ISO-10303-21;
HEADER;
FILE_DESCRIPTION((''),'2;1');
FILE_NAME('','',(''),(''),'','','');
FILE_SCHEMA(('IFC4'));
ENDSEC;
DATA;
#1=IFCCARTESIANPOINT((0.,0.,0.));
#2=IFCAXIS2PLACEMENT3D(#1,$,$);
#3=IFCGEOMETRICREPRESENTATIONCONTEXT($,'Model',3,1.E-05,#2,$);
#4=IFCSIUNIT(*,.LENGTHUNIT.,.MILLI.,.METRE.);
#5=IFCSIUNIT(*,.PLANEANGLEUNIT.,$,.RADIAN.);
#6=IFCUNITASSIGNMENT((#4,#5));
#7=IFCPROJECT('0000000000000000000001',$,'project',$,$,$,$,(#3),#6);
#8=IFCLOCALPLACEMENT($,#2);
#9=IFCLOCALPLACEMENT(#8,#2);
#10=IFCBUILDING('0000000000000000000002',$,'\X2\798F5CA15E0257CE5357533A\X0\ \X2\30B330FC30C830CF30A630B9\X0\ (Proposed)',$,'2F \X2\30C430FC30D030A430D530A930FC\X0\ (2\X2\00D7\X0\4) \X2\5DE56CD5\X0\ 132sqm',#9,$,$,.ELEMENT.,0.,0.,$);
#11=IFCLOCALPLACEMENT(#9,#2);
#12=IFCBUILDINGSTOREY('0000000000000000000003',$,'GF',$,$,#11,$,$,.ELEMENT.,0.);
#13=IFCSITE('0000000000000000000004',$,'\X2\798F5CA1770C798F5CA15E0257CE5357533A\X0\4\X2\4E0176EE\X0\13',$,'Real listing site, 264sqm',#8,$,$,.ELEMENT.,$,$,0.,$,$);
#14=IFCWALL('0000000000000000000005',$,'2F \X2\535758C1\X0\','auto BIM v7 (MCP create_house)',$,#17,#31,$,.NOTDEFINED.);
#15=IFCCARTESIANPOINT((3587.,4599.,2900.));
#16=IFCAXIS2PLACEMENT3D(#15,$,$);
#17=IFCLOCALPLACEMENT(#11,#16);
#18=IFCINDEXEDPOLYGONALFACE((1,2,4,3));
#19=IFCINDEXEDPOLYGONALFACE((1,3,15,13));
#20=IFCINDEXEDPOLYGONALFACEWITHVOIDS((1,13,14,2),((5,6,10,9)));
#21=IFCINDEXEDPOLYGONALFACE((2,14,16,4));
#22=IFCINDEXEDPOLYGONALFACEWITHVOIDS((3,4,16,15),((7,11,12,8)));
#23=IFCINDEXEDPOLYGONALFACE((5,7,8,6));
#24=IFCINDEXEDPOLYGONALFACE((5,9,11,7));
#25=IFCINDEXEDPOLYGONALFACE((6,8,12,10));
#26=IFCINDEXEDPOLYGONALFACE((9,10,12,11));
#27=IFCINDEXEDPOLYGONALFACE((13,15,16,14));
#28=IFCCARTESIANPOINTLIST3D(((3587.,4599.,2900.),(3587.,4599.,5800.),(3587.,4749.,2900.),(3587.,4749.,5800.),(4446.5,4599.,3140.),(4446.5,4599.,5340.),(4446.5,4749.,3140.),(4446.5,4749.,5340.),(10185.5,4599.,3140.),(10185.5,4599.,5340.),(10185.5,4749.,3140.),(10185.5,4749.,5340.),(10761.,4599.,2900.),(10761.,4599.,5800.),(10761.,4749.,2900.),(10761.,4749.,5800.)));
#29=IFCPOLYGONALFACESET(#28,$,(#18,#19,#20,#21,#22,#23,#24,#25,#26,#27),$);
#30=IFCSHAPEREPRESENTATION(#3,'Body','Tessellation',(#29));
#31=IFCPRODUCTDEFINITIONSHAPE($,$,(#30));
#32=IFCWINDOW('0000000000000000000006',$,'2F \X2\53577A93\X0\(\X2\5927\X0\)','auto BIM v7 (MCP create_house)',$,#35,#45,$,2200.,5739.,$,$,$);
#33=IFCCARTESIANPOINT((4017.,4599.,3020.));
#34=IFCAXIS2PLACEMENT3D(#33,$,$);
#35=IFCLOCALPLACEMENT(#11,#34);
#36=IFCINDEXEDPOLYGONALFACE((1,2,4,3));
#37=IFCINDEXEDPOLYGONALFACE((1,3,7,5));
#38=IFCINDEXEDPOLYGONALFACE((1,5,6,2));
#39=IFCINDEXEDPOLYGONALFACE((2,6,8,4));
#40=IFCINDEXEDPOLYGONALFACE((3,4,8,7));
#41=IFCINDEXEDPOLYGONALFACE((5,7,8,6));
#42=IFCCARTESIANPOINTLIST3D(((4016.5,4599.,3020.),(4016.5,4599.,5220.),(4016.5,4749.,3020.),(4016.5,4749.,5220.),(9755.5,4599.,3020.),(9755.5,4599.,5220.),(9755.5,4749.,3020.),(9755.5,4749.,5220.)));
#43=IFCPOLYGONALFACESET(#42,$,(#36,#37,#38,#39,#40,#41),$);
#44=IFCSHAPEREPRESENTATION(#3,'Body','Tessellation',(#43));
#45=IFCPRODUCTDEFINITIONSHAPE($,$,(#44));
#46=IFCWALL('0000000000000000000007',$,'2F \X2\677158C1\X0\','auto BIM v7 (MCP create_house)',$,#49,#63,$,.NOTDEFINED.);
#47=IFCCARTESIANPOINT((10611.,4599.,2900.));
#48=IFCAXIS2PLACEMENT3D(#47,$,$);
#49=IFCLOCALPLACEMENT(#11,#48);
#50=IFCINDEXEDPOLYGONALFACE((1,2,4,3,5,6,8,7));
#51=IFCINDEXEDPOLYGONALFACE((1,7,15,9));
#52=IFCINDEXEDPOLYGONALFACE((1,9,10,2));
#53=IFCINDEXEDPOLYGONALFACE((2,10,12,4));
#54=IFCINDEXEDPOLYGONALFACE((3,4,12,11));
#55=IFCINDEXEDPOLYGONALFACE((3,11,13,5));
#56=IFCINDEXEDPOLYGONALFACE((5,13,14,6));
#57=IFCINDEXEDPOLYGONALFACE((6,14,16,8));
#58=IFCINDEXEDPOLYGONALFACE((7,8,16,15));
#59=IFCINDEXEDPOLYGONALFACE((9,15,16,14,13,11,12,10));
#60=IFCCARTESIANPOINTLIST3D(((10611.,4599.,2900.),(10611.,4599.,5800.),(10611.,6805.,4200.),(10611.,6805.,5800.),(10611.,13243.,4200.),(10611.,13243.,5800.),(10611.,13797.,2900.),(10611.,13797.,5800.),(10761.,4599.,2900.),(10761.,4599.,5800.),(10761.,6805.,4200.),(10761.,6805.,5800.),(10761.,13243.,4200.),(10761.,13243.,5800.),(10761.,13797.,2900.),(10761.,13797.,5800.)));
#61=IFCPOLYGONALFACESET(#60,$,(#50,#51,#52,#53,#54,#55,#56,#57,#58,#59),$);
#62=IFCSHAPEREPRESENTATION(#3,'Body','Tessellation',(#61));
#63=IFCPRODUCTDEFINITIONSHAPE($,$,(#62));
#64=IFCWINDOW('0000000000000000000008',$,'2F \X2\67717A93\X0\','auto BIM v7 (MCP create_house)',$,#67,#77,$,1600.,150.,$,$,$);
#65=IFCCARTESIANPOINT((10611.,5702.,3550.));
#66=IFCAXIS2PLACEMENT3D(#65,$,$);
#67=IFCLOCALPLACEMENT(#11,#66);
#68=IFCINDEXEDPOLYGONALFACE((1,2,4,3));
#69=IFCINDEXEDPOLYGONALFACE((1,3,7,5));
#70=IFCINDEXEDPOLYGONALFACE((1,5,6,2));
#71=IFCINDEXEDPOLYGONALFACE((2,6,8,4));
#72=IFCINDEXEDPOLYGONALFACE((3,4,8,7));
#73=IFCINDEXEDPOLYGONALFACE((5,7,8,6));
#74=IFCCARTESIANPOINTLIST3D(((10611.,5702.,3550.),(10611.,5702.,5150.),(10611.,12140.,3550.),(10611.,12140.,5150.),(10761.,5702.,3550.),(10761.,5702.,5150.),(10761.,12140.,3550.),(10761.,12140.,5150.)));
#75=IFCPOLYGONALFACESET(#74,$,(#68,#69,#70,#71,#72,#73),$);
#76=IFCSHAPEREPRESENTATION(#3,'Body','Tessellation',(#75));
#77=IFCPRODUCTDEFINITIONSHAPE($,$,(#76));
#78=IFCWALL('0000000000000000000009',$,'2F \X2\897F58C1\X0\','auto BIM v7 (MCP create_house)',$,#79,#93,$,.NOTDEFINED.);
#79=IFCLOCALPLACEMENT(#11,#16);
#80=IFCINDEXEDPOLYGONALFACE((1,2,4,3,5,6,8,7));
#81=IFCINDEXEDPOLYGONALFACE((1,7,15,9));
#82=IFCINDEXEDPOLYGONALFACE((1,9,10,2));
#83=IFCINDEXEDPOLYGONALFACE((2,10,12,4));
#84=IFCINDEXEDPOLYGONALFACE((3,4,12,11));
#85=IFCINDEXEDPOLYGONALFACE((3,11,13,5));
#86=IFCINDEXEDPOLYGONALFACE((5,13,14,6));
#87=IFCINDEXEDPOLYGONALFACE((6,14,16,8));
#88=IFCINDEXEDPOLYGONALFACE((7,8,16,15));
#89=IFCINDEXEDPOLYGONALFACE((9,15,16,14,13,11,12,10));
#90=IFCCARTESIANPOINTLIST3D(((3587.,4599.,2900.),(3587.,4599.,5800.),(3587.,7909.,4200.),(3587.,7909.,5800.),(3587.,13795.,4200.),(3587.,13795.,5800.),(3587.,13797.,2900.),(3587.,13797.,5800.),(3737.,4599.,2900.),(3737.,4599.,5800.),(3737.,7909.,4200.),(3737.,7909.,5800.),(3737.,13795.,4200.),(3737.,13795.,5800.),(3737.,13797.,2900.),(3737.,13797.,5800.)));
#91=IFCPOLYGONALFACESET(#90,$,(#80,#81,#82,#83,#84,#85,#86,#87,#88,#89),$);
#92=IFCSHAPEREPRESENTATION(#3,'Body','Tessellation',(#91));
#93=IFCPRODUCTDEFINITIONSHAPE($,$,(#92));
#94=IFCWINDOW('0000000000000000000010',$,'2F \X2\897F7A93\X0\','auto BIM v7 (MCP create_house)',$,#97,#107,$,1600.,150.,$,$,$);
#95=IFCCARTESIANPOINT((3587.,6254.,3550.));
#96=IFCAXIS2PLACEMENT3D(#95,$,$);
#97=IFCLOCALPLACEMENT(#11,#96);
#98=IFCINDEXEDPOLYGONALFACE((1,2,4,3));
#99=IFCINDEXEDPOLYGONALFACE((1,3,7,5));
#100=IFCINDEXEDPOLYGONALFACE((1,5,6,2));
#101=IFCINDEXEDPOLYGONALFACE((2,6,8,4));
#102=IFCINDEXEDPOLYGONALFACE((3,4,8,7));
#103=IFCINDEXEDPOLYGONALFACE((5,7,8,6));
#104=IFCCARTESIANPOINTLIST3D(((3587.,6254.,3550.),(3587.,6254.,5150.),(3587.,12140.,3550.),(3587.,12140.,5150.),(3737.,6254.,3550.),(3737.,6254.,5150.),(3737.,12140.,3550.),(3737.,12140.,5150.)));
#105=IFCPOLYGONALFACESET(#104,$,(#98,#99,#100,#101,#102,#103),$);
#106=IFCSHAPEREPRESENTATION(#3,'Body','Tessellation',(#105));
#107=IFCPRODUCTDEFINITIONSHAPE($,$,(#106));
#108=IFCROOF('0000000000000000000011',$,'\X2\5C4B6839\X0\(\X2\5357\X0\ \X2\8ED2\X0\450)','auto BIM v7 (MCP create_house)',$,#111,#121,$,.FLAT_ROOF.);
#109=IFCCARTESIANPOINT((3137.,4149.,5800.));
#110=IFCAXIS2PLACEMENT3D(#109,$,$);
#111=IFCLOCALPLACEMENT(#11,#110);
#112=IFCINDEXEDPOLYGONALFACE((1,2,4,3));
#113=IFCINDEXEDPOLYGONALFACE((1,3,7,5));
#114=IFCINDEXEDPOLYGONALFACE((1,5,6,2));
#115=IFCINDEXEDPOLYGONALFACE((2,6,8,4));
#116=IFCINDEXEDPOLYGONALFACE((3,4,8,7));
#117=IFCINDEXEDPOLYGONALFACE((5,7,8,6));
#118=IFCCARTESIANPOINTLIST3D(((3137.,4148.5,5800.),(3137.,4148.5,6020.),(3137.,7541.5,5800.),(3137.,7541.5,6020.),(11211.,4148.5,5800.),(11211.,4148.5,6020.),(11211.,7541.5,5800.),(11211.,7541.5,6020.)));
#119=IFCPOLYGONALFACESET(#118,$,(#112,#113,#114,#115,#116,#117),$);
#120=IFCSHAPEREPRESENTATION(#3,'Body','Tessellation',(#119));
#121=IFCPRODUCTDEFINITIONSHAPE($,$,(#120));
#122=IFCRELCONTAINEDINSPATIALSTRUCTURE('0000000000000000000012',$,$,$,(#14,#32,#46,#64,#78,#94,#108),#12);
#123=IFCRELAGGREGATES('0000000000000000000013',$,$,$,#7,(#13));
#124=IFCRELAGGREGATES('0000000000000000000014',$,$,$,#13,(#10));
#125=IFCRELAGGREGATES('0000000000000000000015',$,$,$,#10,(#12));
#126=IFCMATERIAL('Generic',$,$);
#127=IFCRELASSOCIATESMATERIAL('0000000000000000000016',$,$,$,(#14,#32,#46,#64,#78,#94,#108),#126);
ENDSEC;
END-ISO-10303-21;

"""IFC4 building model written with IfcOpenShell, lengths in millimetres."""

from ifc_helpers import new_model, si_unit, frame, frame_2d, origin, place, context, project, spatial, rectangle, extrude, material, element, fill, save


model = new_model("IFC4")

# Units and contexts
model_context = context("Model", 3, precision=1e-05, world=origin())
ifc_project = project(units=[si_unit("LENGTHUNIT", "METRE", prefix="MILLI"), si_unit("PLANEANGLEUNIT", "RADIAN")], contexts=[model_context])

# Site, building, storey
site_placement = place(None, origin())
site = spatial("IfcSite", under=ifc_project, at=site_placement, Name="福岡県福岡市城南区4丁目13", ObjectType="Real listing site, 264sqm", CompositionType="ELEMENT", RefElevation=0.0)
building_placement = place(site_placement, origin())
building = spatial("IfcBuilding", under=site, at=building_placement, Name="福岡市城南区 コートハウス (Proposed)", ObjectType="2F ツーバイフォー (2×4) 工法 132sqm", CompositionType="ELEMENT", ElevationOfRefHeight=0.0, ElevationOfTerrain=0.0)
storey_placement = place(building_placement, origin())
storey = spatial("IfcBuildingStorey", under=building, at=storey_placement, Name="GF", CompositionType="ELEMENT", Elevation=0.0)

# Shared definitions
ifc_material = material(Name="Generic")

# Walls, openings, windows
wall_1_placement = place(storey_placement, frame((3587.0, 4599.0, 2900.0)))
wall_1 = element("IfcWall", 1, at=wall_1_placement, inside=storey, material=ifc_material, Name="2F 南壁", Description="auto BIM v7 (MCP create_house)", PredefinedType="NOTDEFINED", context=model_context, shape_type="SweptSolid", body=[
    extrude(rectangle(XDim=7174.0, YDim=150.0, at=frame_2d((3587.0, 75.0))), frame((3587.0, 4599.0, 2900.0)), (0.0, 0.0, 1.0), 2900.0),
])
opening_1_placement = place(storey_placement, frame((4017.0, 4599.0, 3020.0)))
opening_1 = element("IfcOpeningElement", 2, at=opening_1_placement, cuts=wall_1, PredefinedType="NOTDEFINED", context=model_context, shape_type="SweptSolid", body=[
    extrude(rectangle(XDim=5739.0, YDim=150.0, at=frame_2d((2869.0, 75.0))), frame((4017.0, 4599.0, 3020.0)), (0.0, 0.0, 1.0), 2200.0),
])
window_1_placement = place(storey_placement, frame((4017.0, 4599.0, 3020.0)))
window_1 = element("IfcWindow", 3, at=window_1_placement, inside=storey, material=ifc_material, Name="2F 南窓(大)", Description="auto BIM v7 (MCP create_house)", OverallHeight=2200.0, OverallWidth=5739.0, context=model_context, shape_type="SweptSolid", body=[
    extrude(rectangle(XDim=5739.0, YDim=150.0, at=frame_2d((2869.0, 75.0))), frame((4017.0, 4599.0, 3020.0)), (0.0, 0.0, 1.0), 2200.0),
])
fill(opening_1, window_1)
wall_2_placement = place(storey_placement, frame((10611.0, 4599.0, 2900.0)))
wall_2 = element("IfcWall", 4, at=wall_2_placement, inside=storey, material=ifc_material, Name="2F 東壁", Description="auto BIM v7 (MCP create_house)", PredefinedType="NOTDEFINED", context=model_context, shape_type="SweptSolid", body=[
    extrude(rectangle(XDim=150.0, YDim=9198.0, at=frame_2d((75.0, 4599.0))), frame((10611.0, 4599.0, 2900.0)), (0.0, 0.0, 1.0), 2900.0),
])
opening_2_placement = place(storey_placement, frame((10611.0, 5702.0, 3550.0)))
opening_2 = element("IfcOpeningElement", 5, at=opening_2_placement, cuts=wall_2, PredefinedType="NOTDEFINED", context=model_context, shape_type="SweptSolid", body=[
    extrude(rectangle(XDim=150.0, YDim=6438.0, at=frame_2d((75.0, 3219.0))), frame((10611.0, 5702.0, 3550.0)), (0.0, 0.0, 1.0), 1600.0),
])
window_2_placement = place(storey_placement, frame((10611.0, 5702.0, 3550.0)))
window_2 = element("IfcWindow", 6, at=window_2_placement, inside=storey, material=ifc_material, Name="2F 東窓", Description="auto BIM v7 (MCP create_house)", OverallHeight=1600.0, OverallWidth=150.0, context=model_context, shape_type="SweptSolid", body=[
    extrude(rectangle(XDim=150.0, YDim=6438.0, at=frame_2d((75.0, 3219.0))), frame((10611.0, 5702.0, 3550.0)), (0.0, 0.0, 1.0), 1600.0),
])
fill(opening_2, window_2)
wall_3_placement = place(storey_placement, frame((3587.0, 4599.0, 2900.0)))
wall_3 = element("IfcWall", 7, at=wall_3_placement, inside=storey, material=ifc_material, Name="2F 西壁", Description="auto BIM v7 (MCP create_house)", PredefinedType="NOTDEFINED", context=model_context, shape_type="SweptSolid", body=[
    extrude(rectangle(XDim=150.0, YDim=9198.0, at=frame_2d((75.0, 4599.0))), frame((3587.0, 4599.0, 2900.0)), (0.0, 0.0, 1.0), 2900.0),
])
opening_3_placement = place(storey_placement, frame((3587.0, 6254.0, 3550.0)))
opening_3 = element("IfcOpeningElement", 8, at=opening_3_placement, cuts=wall_3, PredefinedType="NOTDEFINED", context=model_context, shape_type="SweptSolid", body=[
    extrude(rectangle(XDim=150.0, YDim=5886.0, at=frame_2d((75.0, 2943.0))), frame((3587.0, 6254.0, 3550.0)), (0.0, 0.0, 1.0), 1600.0),
])
window_3_placement = place(storey_placement, frame((3587.0, 6254.0, 3550.0)))
window_3 = element("IfcWindow", 9, at=window_3_placement, inside=storey, material=ifc_material, Name="2F 西窓", Description="auto BIM v7 (MCP create_house)", OverallHeight=1600.0, OverallWidth=150.0, context=model_context, shape_type="SweptSolid", body=[
    extrude(rectangle(XDim=150.0, YDim=5886.0, at=frame_2d((75.0, 2943.0))), frame((3587.0, 6254.0, 3550.0)), (0.0, 0.0, 1.0), 1600.0),
])
fill(opening_3, window_3)

# Roof
roof_1_placement = place(storey_placement, frame((3137.0, 4149.0, 5800.0)))
element("IfcRoof", 10, at=roof_1_placement, inside=storey, material=ifc_material, Name="屋根(南 軒450)", Description="auto BIM v7 (MCP create_house)", PredefinedType="FLAT_ROOF", context=model_context, shape_type="SweptSolid", body=[
    extrude(rectangle(XDim=8074.0, YDim=3393.0, at=frame_2d((4037.0, 1696.0))), frame((3137.0, 4149.0, 5800.0)), (0.0, 0.0, 1.0), 220.0),
])

save(model, "model.ifc")
